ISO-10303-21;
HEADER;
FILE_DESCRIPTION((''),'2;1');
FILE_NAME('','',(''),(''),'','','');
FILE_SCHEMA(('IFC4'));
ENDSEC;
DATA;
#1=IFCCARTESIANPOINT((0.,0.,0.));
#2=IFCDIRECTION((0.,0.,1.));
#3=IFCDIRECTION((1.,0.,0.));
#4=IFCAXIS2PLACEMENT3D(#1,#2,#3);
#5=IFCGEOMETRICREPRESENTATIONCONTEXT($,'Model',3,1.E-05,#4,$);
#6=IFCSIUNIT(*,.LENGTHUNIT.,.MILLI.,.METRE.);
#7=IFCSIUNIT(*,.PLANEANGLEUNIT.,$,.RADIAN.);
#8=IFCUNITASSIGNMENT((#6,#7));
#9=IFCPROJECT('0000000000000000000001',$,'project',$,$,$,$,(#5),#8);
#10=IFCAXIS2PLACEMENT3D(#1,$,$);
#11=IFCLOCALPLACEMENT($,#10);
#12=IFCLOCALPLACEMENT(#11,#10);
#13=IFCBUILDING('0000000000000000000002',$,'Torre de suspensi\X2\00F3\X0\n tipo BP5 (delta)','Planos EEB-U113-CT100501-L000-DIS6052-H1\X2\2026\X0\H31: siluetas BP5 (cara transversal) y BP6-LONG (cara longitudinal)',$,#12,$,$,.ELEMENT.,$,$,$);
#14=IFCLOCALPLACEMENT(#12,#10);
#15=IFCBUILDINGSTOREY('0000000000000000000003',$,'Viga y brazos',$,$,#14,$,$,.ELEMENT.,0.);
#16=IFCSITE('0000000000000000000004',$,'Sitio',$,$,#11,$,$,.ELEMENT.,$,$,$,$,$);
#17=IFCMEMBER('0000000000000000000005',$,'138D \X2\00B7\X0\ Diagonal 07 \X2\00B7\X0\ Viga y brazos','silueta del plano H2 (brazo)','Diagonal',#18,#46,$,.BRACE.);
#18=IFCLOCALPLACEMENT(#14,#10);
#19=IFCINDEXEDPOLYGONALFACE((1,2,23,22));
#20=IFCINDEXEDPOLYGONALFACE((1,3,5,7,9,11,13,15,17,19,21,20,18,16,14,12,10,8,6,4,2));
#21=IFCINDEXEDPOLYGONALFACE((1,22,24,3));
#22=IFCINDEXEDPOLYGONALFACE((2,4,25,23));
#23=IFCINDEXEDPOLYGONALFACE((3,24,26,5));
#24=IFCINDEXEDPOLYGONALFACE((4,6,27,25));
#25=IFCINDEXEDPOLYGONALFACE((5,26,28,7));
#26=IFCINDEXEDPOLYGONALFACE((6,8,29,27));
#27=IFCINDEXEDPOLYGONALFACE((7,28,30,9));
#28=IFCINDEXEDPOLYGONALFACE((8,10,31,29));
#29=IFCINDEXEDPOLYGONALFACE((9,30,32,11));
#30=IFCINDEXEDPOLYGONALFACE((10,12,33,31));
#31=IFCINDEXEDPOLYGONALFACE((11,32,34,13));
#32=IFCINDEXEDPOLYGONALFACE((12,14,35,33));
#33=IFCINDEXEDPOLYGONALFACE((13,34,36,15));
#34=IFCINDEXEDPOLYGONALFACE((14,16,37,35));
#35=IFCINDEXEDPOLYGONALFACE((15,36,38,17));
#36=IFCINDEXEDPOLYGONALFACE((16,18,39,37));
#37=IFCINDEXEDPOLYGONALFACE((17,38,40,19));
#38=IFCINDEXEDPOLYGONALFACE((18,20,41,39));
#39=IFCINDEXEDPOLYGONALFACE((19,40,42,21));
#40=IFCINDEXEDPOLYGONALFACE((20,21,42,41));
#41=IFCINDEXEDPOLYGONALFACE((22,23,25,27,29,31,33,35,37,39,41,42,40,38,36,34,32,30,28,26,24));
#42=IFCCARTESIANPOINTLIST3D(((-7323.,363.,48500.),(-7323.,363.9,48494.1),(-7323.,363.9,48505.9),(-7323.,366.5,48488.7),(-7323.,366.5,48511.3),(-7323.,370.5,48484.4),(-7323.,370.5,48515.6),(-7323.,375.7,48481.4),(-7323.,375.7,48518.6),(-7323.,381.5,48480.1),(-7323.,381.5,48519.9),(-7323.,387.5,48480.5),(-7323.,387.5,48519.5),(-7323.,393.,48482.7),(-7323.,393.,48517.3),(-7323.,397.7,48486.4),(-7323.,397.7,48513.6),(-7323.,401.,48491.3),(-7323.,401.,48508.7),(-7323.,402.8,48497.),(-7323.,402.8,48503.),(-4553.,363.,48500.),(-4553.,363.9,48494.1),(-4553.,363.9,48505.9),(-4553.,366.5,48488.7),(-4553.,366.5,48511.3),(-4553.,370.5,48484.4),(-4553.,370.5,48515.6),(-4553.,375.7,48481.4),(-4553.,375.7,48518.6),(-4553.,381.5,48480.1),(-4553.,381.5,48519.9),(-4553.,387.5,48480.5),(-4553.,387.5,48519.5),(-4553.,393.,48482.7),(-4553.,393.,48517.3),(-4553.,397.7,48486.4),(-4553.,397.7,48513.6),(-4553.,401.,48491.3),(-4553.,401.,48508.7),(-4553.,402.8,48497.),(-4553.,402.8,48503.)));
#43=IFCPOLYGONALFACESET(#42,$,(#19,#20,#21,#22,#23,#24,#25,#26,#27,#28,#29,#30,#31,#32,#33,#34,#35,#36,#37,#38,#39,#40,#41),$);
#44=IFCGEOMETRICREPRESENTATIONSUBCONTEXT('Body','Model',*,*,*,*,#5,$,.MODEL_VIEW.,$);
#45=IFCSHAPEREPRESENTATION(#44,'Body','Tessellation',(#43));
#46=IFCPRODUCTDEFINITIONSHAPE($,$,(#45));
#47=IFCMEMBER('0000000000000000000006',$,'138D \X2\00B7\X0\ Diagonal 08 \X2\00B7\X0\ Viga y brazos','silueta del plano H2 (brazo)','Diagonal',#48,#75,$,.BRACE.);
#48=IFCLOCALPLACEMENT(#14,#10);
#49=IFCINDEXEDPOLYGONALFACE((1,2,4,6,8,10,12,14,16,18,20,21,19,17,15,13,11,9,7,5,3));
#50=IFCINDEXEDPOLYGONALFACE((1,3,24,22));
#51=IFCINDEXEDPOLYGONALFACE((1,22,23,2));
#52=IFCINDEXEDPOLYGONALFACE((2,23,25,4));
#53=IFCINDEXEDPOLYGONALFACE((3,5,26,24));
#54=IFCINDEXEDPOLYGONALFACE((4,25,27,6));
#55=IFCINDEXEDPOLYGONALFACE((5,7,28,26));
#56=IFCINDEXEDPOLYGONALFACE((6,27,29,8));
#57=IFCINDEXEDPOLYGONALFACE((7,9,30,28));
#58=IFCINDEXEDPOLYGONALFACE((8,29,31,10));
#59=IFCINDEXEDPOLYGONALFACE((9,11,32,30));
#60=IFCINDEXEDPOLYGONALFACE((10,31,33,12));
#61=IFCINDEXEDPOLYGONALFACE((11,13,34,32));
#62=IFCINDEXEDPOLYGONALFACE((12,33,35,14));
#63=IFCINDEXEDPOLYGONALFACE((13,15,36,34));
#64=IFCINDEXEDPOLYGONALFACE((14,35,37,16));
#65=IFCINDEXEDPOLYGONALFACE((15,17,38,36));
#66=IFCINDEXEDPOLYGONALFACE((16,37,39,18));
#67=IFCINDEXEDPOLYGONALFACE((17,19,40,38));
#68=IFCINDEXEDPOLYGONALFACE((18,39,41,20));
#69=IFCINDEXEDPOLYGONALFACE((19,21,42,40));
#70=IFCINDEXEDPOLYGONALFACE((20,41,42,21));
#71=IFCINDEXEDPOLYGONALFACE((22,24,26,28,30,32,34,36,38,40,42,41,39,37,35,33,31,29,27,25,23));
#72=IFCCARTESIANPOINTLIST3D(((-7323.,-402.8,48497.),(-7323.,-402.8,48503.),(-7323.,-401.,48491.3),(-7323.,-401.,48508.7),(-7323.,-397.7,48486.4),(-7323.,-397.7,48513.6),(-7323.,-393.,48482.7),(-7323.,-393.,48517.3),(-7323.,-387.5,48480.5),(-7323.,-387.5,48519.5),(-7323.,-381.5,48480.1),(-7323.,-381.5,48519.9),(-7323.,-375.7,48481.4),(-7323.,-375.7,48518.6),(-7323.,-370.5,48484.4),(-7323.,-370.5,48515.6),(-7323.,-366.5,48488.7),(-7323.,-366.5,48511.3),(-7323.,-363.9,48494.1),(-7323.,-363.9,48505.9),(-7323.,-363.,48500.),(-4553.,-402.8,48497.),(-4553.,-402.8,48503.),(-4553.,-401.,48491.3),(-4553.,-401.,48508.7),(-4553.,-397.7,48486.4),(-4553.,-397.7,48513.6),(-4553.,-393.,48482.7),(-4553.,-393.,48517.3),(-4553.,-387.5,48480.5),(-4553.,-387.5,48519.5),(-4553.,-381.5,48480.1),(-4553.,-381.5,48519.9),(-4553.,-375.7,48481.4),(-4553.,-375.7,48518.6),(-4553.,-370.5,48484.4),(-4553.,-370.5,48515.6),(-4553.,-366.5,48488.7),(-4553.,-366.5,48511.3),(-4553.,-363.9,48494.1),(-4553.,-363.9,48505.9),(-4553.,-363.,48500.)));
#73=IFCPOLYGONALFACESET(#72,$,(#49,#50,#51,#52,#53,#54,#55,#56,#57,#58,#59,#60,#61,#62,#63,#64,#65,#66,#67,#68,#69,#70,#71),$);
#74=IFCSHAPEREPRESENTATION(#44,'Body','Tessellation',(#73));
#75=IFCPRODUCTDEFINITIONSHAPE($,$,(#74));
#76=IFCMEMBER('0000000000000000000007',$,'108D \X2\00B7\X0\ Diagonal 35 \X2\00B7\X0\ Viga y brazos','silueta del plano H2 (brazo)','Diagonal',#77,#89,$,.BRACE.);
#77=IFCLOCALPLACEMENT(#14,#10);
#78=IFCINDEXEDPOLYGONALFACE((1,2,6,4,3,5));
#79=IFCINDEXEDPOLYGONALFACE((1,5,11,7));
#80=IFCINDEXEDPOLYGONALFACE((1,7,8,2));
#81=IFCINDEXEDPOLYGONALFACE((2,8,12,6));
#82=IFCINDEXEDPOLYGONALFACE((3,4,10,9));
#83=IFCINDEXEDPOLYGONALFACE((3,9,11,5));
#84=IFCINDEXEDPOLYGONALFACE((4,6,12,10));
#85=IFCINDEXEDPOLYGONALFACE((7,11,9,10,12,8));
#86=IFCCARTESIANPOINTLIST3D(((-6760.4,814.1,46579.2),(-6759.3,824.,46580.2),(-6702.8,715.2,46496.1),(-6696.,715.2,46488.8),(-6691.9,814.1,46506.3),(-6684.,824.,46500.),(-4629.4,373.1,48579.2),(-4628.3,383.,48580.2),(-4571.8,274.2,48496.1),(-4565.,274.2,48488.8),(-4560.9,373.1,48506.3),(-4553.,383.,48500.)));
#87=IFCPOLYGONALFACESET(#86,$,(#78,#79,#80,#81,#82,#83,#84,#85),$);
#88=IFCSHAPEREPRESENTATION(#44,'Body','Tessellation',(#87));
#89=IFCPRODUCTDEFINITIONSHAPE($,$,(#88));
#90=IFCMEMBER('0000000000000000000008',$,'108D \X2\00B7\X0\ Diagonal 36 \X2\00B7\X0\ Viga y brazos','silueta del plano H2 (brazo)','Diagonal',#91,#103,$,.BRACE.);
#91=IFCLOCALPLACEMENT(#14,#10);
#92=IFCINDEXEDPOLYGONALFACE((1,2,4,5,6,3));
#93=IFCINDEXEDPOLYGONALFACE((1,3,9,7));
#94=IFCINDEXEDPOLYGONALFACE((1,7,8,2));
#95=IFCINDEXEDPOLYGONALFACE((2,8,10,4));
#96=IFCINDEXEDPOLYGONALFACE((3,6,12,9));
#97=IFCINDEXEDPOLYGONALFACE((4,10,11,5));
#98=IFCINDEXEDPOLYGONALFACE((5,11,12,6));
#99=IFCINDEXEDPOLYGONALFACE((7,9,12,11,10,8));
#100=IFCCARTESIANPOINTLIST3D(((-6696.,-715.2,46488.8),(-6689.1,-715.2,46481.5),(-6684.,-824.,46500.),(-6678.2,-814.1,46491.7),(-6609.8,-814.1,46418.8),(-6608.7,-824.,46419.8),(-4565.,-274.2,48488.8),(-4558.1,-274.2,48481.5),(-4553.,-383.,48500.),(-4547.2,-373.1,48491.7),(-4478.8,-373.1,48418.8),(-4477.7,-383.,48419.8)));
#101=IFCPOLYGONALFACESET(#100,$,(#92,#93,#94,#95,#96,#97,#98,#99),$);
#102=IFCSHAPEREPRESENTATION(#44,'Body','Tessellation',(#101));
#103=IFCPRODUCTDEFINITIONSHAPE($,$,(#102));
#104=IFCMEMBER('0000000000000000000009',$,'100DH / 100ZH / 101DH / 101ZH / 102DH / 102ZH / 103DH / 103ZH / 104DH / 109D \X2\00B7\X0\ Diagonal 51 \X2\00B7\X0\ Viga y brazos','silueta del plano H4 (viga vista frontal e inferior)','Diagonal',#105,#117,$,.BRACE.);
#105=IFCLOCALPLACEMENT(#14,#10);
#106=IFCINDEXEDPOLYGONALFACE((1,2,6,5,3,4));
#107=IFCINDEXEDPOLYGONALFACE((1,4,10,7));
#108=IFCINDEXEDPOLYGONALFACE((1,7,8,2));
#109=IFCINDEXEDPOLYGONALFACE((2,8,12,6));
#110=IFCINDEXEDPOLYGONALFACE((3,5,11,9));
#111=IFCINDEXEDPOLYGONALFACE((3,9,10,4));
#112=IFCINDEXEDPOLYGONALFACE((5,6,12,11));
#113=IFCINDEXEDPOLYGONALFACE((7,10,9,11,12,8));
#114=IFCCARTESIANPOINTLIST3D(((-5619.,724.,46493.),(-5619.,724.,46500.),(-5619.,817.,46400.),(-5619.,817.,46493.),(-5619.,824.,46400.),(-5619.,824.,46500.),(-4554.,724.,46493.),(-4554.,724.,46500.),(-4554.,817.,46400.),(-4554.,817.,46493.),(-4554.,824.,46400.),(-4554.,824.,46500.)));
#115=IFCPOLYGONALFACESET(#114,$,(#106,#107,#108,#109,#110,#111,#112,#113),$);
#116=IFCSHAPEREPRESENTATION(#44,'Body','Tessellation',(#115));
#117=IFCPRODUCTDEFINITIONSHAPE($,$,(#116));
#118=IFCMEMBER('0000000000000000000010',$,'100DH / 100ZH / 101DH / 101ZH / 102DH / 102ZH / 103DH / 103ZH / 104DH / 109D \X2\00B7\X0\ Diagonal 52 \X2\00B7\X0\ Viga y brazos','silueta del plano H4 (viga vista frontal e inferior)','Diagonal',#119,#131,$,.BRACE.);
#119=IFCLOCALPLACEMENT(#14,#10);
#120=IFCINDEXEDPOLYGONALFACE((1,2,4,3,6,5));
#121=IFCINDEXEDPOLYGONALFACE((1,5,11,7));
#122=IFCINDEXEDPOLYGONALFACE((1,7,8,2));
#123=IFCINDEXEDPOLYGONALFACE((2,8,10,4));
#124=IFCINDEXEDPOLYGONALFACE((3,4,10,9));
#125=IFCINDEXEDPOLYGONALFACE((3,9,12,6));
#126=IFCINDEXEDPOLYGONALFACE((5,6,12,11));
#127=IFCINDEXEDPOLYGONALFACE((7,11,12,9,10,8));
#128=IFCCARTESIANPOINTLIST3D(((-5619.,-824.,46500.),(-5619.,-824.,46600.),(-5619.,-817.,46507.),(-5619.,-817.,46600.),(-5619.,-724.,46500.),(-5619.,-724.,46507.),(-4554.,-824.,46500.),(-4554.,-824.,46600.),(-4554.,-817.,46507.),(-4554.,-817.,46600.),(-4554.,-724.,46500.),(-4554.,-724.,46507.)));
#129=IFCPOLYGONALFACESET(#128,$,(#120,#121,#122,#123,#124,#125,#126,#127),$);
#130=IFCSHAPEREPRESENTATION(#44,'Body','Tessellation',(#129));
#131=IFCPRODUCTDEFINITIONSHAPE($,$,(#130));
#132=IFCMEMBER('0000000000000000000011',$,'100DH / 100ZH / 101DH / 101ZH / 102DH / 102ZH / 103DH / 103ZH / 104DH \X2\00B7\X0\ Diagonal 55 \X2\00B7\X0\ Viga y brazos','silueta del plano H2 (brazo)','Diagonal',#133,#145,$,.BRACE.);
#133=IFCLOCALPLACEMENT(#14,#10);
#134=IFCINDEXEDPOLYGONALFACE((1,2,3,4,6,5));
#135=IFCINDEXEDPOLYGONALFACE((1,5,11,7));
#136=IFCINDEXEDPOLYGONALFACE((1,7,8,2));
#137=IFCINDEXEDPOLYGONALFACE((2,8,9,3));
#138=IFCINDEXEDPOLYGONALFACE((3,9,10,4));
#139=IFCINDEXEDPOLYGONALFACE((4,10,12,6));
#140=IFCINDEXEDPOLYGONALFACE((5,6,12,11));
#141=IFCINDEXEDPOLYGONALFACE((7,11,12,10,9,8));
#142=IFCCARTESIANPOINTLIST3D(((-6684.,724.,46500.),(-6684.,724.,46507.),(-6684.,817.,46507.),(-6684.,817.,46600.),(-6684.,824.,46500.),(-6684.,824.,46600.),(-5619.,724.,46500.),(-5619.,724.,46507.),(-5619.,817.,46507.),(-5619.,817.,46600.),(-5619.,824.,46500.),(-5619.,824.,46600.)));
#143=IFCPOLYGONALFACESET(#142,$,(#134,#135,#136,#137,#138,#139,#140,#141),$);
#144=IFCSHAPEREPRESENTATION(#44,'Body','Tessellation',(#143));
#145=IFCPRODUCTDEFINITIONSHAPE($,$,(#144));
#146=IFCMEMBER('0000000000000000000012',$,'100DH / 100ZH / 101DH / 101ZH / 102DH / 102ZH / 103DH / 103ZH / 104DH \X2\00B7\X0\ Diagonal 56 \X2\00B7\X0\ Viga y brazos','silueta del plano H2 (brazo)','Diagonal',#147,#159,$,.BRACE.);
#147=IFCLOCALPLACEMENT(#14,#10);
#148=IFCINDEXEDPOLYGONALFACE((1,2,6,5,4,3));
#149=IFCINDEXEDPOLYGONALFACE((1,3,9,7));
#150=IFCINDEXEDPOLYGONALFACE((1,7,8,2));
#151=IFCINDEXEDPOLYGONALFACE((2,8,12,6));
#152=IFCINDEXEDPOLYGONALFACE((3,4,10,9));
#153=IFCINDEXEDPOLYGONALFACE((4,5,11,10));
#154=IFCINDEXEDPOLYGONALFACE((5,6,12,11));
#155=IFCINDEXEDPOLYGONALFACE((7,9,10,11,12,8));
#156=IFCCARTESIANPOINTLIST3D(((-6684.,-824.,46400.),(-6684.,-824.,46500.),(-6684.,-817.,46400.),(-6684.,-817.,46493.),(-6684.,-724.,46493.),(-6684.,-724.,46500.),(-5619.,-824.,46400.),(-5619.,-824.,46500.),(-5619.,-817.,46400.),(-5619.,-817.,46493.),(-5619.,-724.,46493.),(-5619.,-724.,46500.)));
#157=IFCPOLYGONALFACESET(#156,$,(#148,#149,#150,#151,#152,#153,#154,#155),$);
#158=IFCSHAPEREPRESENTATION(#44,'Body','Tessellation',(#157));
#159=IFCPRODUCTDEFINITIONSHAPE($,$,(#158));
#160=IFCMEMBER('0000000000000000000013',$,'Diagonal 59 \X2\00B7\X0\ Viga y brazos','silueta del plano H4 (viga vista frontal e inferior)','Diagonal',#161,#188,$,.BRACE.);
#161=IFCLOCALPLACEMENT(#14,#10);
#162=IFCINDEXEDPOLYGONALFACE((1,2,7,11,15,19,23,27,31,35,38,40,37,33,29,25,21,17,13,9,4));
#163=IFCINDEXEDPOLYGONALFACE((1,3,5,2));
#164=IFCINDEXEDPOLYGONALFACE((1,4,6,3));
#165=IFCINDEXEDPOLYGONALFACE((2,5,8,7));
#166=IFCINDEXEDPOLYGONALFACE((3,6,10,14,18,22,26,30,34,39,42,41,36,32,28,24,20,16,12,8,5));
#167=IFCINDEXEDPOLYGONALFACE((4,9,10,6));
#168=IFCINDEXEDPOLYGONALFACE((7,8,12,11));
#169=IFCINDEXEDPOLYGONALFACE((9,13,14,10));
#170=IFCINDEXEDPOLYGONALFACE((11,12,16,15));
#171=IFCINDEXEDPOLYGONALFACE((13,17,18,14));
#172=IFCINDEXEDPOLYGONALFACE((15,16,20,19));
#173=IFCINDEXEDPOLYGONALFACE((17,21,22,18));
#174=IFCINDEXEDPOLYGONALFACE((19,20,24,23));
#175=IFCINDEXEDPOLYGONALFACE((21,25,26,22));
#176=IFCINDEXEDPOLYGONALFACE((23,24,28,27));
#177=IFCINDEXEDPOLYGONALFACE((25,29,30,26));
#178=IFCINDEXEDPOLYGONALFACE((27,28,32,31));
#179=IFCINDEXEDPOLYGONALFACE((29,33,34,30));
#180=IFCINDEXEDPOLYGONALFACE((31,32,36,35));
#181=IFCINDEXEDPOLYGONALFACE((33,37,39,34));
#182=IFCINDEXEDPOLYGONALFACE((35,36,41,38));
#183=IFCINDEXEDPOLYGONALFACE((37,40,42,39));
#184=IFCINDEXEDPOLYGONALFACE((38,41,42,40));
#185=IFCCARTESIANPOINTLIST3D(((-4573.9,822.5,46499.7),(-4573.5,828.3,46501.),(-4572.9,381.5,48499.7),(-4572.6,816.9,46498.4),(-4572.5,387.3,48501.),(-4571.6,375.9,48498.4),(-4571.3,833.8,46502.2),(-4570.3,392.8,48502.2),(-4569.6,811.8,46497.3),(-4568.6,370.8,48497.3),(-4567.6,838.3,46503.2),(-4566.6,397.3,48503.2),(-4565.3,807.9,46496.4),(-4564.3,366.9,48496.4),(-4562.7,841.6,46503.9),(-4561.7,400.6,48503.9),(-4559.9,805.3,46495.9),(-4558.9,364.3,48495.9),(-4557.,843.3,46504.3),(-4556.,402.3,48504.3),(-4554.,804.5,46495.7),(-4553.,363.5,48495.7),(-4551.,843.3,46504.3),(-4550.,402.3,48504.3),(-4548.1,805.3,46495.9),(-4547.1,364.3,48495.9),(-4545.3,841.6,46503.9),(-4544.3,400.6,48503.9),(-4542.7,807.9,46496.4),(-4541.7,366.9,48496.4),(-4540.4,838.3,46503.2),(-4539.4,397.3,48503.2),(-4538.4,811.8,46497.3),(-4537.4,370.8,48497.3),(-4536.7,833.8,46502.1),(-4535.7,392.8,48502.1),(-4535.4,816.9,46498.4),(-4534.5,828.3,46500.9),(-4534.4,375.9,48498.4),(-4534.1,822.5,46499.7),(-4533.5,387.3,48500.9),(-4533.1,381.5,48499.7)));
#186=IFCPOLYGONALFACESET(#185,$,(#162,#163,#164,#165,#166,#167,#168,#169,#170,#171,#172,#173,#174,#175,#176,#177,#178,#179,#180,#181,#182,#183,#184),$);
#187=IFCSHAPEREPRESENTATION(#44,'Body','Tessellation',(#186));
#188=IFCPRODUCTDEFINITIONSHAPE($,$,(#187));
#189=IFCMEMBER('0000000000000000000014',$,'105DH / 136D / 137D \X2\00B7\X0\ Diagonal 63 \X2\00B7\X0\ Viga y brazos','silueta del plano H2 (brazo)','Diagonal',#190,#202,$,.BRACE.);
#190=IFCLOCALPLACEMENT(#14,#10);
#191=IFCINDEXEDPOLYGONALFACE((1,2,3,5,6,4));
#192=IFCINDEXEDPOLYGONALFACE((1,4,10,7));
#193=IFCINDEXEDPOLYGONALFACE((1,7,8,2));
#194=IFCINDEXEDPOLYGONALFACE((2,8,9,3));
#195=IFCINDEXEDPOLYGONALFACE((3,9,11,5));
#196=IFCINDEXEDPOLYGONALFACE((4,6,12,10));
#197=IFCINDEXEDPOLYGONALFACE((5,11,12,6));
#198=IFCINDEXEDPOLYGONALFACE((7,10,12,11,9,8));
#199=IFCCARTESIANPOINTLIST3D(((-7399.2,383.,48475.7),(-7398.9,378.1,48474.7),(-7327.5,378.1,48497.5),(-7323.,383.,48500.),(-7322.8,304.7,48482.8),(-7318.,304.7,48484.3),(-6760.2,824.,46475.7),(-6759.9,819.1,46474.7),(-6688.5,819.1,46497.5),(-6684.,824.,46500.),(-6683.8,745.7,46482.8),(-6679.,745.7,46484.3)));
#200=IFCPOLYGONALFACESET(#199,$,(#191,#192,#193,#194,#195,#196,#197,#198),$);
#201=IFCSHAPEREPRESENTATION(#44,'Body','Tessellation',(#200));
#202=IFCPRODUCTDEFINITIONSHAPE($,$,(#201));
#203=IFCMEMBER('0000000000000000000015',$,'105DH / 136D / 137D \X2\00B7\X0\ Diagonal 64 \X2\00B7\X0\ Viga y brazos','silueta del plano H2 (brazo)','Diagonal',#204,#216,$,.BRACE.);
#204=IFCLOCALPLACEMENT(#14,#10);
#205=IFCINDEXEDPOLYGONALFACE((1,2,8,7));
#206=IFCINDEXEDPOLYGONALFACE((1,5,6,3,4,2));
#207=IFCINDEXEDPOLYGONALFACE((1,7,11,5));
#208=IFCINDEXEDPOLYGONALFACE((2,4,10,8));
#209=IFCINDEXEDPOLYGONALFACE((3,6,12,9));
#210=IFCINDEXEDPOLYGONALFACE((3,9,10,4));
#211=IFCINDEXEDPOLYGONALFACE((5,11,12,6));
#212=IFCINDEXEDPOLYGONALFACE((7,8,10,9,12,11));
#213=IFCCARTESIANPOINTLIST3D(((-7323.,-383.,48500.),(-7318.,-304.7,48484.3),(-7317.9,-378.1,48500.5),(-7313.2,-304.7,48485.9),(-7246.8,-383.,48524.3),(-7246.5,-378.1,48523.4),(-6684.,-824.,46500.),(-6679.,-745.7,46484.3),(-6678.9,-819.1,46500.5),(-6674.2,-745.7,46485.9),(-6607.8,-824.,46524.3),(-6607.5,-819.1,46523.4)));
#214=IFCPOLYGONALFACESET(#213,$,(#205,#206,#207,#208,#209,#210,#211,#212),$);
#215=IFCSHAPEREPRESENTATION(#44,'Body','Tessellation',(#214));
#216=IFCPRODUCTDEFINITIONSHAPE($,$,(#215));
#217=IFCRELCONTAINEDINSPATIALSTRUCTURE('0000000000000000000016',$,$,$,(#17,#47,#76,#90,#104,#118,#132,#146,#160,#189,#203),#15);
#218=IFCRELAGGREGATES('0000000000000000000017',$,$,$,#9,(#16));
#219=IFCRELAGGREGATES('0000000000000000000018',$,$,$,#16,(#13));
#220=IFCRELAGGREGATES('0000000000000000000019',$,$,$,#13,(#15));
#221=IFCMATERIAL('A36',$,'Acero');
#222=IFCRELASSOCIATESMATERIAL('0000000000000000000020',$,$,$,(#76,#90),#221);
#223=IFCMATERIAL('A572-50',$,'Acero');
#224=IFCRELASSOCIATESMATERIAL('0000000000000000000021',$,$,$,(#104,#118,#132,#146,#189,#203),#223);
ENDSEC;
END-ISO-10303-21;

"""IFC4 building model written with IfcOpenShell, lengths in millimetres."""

from ifc_helpers import new_model, si_unit, frame, frame_2d, origin, origin_with_axes, place, context, subcontext, project, spatial, circle, l_section, extrude, material, element, save


model = new_model("IFC4")

# Units and contexts
model_context = context("Model", 3, precision=1e-05, world=origin_with_axes())
body_context = subcontext(model_context, "Body", "Model", "MODEL_VIEW")
ifc_project = project(units=[si_unit("LENGTHUNIT", "METRE", prefix="MILLI"), si_unit("PLANEANGLEUNIT", "RADIAN")], contexts=[model_context])

# Site, building, storey
site_placement = place(None, origin())
site = spatial("IfcSite", under=ifc_project, at=site_placement, Name="Sitio", CompositionType="ELEMENT")
building_placement = place(site_placement, origin())
building = spatial("IfcBuilding", under=site, at=building_placement, Name="Torre de suspensión tipo BP5 (delta)", Description="Planos EEB-U113-CT100501-L000-DIS6052-H1…H31: siluetas BP5 (cara transversal) y BP6-LONG (cara longitudinal)", CompositionType="ELEMENT")
storey_placement = place(building_placement, origin())
storey = spatial("IfcBuildingStorey", under=building, at=storey_placement, Name="Viga y brazos", CompositionType="ELEMENT", Elevation=0.0)

# Members
for number, where, z_axis, x_axis, name in (
    (1, (-7323.0, 383.0, 48500.0), (1.0, 0.0, 0.0), (0.0, -1.0, 0.0), "138D · Diagonal 07 · Viga y brazos"),
    (2, (-7323.0, -383.0, 48500.0), (1.0, 0.0, 0.0), (0.0, 1.0, 0.0), "138D · Diagonal 08 · Viga y brazos"),
):
    element("IfcMember", number, at=place(storey_placement, frame(where, z_axis=z_axis, x_axis=x_axis)), inside=storey, Name=name, Description="silueta del plano H2 (brazo)", ObjectType="Diagonal", PredefinedType="BRACE", context=body_context, shape_type="SweptSolid", body=[
        extrude(circle(Radius=20.0), None, (0.0, 0.0, 1.0), 2770.0),
    ])
ifc_material_1 = material(Name="A36", Category="Acero")
for number, where, z_axis, x_axis, name in (
    (3, (-4553.0, 383.0, 48500.0), (-0.721001, 0.149208, -0.676679), (-0.108797, -0.988806, -0.102109), "108D · Diagonal 35 · Viga y brazos"),
    (4, (-4553.0, -383.0, 48500.0), (-0.721001, -0.149208, -0.676679), (-0.108797, 0.988806, -0.102109), "108D · Diagonal 36 · Viga y brazos"),
):
    element("IfcMember", number, at=place(storey_placement, frame(where, z_axis=z_axis, x_axis=x_axis)), inside=storey, material=ifc_material_1, Name=name, Description="silueta del plano H2 (brazo)", ObjectType="Diagonal", PredefinedType="BRACE", context=body_context, shape_type="SweptSolid", body=[
        extrude(l_section(Depth=110.0, Width=110.0, Thickness=10.0, at=frame_2d((55.0, 55.0))), None, (0.0, 0.0, 1.0), 2955.6),
    ])
ifc_material_2 = material(Name="A572-50", Category="Acero")
for number, where, z_axis, x_axis, name, description in (
    (5, (-5619.0, 824.0, 46500.0), (1.0, 0.0, 0.0), (0.0, -1.0, 0.0), "100DH / 100ZH / 101DH / 101ZH / 102DH / 102ZH / 103DH / 103ZH / 104DH / 109D · Diagonal 51 · Viga y brazos", "silueta del plano H4 (viga vista frontal e inferior)"),
    (6, (-5619.0, -824.0, 46500.0), (1.0, 0.0, 0.0), (0.0, 1.0, 0.0), "100DH / 100ZH / 101DH / 101ZH / 102DH / 102ZH / 103DH / 103ZH / 104DH / 109D · Diagonal 52 · Viga y brazos", "silueta del plano H4 (viga vista frontal e inferior)"),
    (7, (-5619.0, 824.0, 46500.0), (-1.0, 0.0, 0.0), (0.0, -1.0, 0.0), "100DH / 100ZH / 101DH / 101ZH / 102DH / 102ZH / 103DH / 103ZH / 104DH · Diagonal 55 · Viga y brazos", "silueta del plano H2 (brazo)"),
    (8, (-5619.0, -824.0, 46500.0), (-1.0, 0.0, 0.0), (0.0, 1.0, 0.0), "100DH / 100ZH / 101DH / 101ZH / 102DH / 102ZH / 103DH / 103ZH / 104DH · Diagonal 56 · Viga y brazos", "silueta del plano H2 (brazo)"),
):
    element("IfcMember", number, at=place(storey_placement, frame(where, z_axis=z_axis, x_axis=x_axis)), inside=storey, material=ifc_material_2, Name=name, Description=description, ObjectType="Diagonal", PredefinedType="BRACE", context=body_context, shape_type="SweptSolid", body=[
        extrude(l_section(Depth=100.0, Width=100.0, Thickness=7.0, at=frame_2d((50.0, 50.0))), None, (0.0, 0.0, 1.0), 1065.0),
    ])
member_placement = place(storey_placement, frame((-4553.0, 383.0, 48500.0), z_axis=(-0.000488, 0.215327, -0.976542), x_axis=(-0.000108, -0.976542, -0.215327)))
element("IfcMember", 9, at=member_placement, inside=storey, Name="Diagonal 59 · Viga y brazos", Description="silueta del plano H4 (viga vista frontal e inferior)", ObjectType="Diagonal", PredefinedType="BRACE", context=body_context, shape_type="SweptSolid", body=[
    extrude(circle(Radius=20.0), None, (0.0, 0.0, 1.0), 2048.0),
])
for number, where, z_axis, x_axis, name in (
    (10, (-7323.0, 383.0, 48500.0), (0.297845, 0.205555, -0.932221), (0.062559, -0.978646, -0.195804), "105DH / 136D / 137D · Diagonal 63 · Viga y brazos"),
    (11, (-7323.0, -383.0, 48500.0), (0.297845, -0.205555, -0.932221), (0.062559, 0.978646, -0.195804), "105DH / 136D / 137D · Diagonal 64 · Viga y brazos"),
):
    element("IfcMember", number, at=place(storey_placement, frame(where, z_axis=z_axis, x_axis=x_axis)), inside=storey, material=ifc_material_2, Name=name, Description="silueta del plano H2 (brazo)", ObjectType="Diagonal", PredefinedType="BRACE", context=body_context, shape_type="SweptSolid", body=[
        extrude(l_section(Depth=80.0, Width=80.0, Thickness=5.0, at=frame_2d((40.0, 40.0))), None, (0.0, 0.0, 1.0), 2145.4),
    ])

save(model, "model.ifc")
